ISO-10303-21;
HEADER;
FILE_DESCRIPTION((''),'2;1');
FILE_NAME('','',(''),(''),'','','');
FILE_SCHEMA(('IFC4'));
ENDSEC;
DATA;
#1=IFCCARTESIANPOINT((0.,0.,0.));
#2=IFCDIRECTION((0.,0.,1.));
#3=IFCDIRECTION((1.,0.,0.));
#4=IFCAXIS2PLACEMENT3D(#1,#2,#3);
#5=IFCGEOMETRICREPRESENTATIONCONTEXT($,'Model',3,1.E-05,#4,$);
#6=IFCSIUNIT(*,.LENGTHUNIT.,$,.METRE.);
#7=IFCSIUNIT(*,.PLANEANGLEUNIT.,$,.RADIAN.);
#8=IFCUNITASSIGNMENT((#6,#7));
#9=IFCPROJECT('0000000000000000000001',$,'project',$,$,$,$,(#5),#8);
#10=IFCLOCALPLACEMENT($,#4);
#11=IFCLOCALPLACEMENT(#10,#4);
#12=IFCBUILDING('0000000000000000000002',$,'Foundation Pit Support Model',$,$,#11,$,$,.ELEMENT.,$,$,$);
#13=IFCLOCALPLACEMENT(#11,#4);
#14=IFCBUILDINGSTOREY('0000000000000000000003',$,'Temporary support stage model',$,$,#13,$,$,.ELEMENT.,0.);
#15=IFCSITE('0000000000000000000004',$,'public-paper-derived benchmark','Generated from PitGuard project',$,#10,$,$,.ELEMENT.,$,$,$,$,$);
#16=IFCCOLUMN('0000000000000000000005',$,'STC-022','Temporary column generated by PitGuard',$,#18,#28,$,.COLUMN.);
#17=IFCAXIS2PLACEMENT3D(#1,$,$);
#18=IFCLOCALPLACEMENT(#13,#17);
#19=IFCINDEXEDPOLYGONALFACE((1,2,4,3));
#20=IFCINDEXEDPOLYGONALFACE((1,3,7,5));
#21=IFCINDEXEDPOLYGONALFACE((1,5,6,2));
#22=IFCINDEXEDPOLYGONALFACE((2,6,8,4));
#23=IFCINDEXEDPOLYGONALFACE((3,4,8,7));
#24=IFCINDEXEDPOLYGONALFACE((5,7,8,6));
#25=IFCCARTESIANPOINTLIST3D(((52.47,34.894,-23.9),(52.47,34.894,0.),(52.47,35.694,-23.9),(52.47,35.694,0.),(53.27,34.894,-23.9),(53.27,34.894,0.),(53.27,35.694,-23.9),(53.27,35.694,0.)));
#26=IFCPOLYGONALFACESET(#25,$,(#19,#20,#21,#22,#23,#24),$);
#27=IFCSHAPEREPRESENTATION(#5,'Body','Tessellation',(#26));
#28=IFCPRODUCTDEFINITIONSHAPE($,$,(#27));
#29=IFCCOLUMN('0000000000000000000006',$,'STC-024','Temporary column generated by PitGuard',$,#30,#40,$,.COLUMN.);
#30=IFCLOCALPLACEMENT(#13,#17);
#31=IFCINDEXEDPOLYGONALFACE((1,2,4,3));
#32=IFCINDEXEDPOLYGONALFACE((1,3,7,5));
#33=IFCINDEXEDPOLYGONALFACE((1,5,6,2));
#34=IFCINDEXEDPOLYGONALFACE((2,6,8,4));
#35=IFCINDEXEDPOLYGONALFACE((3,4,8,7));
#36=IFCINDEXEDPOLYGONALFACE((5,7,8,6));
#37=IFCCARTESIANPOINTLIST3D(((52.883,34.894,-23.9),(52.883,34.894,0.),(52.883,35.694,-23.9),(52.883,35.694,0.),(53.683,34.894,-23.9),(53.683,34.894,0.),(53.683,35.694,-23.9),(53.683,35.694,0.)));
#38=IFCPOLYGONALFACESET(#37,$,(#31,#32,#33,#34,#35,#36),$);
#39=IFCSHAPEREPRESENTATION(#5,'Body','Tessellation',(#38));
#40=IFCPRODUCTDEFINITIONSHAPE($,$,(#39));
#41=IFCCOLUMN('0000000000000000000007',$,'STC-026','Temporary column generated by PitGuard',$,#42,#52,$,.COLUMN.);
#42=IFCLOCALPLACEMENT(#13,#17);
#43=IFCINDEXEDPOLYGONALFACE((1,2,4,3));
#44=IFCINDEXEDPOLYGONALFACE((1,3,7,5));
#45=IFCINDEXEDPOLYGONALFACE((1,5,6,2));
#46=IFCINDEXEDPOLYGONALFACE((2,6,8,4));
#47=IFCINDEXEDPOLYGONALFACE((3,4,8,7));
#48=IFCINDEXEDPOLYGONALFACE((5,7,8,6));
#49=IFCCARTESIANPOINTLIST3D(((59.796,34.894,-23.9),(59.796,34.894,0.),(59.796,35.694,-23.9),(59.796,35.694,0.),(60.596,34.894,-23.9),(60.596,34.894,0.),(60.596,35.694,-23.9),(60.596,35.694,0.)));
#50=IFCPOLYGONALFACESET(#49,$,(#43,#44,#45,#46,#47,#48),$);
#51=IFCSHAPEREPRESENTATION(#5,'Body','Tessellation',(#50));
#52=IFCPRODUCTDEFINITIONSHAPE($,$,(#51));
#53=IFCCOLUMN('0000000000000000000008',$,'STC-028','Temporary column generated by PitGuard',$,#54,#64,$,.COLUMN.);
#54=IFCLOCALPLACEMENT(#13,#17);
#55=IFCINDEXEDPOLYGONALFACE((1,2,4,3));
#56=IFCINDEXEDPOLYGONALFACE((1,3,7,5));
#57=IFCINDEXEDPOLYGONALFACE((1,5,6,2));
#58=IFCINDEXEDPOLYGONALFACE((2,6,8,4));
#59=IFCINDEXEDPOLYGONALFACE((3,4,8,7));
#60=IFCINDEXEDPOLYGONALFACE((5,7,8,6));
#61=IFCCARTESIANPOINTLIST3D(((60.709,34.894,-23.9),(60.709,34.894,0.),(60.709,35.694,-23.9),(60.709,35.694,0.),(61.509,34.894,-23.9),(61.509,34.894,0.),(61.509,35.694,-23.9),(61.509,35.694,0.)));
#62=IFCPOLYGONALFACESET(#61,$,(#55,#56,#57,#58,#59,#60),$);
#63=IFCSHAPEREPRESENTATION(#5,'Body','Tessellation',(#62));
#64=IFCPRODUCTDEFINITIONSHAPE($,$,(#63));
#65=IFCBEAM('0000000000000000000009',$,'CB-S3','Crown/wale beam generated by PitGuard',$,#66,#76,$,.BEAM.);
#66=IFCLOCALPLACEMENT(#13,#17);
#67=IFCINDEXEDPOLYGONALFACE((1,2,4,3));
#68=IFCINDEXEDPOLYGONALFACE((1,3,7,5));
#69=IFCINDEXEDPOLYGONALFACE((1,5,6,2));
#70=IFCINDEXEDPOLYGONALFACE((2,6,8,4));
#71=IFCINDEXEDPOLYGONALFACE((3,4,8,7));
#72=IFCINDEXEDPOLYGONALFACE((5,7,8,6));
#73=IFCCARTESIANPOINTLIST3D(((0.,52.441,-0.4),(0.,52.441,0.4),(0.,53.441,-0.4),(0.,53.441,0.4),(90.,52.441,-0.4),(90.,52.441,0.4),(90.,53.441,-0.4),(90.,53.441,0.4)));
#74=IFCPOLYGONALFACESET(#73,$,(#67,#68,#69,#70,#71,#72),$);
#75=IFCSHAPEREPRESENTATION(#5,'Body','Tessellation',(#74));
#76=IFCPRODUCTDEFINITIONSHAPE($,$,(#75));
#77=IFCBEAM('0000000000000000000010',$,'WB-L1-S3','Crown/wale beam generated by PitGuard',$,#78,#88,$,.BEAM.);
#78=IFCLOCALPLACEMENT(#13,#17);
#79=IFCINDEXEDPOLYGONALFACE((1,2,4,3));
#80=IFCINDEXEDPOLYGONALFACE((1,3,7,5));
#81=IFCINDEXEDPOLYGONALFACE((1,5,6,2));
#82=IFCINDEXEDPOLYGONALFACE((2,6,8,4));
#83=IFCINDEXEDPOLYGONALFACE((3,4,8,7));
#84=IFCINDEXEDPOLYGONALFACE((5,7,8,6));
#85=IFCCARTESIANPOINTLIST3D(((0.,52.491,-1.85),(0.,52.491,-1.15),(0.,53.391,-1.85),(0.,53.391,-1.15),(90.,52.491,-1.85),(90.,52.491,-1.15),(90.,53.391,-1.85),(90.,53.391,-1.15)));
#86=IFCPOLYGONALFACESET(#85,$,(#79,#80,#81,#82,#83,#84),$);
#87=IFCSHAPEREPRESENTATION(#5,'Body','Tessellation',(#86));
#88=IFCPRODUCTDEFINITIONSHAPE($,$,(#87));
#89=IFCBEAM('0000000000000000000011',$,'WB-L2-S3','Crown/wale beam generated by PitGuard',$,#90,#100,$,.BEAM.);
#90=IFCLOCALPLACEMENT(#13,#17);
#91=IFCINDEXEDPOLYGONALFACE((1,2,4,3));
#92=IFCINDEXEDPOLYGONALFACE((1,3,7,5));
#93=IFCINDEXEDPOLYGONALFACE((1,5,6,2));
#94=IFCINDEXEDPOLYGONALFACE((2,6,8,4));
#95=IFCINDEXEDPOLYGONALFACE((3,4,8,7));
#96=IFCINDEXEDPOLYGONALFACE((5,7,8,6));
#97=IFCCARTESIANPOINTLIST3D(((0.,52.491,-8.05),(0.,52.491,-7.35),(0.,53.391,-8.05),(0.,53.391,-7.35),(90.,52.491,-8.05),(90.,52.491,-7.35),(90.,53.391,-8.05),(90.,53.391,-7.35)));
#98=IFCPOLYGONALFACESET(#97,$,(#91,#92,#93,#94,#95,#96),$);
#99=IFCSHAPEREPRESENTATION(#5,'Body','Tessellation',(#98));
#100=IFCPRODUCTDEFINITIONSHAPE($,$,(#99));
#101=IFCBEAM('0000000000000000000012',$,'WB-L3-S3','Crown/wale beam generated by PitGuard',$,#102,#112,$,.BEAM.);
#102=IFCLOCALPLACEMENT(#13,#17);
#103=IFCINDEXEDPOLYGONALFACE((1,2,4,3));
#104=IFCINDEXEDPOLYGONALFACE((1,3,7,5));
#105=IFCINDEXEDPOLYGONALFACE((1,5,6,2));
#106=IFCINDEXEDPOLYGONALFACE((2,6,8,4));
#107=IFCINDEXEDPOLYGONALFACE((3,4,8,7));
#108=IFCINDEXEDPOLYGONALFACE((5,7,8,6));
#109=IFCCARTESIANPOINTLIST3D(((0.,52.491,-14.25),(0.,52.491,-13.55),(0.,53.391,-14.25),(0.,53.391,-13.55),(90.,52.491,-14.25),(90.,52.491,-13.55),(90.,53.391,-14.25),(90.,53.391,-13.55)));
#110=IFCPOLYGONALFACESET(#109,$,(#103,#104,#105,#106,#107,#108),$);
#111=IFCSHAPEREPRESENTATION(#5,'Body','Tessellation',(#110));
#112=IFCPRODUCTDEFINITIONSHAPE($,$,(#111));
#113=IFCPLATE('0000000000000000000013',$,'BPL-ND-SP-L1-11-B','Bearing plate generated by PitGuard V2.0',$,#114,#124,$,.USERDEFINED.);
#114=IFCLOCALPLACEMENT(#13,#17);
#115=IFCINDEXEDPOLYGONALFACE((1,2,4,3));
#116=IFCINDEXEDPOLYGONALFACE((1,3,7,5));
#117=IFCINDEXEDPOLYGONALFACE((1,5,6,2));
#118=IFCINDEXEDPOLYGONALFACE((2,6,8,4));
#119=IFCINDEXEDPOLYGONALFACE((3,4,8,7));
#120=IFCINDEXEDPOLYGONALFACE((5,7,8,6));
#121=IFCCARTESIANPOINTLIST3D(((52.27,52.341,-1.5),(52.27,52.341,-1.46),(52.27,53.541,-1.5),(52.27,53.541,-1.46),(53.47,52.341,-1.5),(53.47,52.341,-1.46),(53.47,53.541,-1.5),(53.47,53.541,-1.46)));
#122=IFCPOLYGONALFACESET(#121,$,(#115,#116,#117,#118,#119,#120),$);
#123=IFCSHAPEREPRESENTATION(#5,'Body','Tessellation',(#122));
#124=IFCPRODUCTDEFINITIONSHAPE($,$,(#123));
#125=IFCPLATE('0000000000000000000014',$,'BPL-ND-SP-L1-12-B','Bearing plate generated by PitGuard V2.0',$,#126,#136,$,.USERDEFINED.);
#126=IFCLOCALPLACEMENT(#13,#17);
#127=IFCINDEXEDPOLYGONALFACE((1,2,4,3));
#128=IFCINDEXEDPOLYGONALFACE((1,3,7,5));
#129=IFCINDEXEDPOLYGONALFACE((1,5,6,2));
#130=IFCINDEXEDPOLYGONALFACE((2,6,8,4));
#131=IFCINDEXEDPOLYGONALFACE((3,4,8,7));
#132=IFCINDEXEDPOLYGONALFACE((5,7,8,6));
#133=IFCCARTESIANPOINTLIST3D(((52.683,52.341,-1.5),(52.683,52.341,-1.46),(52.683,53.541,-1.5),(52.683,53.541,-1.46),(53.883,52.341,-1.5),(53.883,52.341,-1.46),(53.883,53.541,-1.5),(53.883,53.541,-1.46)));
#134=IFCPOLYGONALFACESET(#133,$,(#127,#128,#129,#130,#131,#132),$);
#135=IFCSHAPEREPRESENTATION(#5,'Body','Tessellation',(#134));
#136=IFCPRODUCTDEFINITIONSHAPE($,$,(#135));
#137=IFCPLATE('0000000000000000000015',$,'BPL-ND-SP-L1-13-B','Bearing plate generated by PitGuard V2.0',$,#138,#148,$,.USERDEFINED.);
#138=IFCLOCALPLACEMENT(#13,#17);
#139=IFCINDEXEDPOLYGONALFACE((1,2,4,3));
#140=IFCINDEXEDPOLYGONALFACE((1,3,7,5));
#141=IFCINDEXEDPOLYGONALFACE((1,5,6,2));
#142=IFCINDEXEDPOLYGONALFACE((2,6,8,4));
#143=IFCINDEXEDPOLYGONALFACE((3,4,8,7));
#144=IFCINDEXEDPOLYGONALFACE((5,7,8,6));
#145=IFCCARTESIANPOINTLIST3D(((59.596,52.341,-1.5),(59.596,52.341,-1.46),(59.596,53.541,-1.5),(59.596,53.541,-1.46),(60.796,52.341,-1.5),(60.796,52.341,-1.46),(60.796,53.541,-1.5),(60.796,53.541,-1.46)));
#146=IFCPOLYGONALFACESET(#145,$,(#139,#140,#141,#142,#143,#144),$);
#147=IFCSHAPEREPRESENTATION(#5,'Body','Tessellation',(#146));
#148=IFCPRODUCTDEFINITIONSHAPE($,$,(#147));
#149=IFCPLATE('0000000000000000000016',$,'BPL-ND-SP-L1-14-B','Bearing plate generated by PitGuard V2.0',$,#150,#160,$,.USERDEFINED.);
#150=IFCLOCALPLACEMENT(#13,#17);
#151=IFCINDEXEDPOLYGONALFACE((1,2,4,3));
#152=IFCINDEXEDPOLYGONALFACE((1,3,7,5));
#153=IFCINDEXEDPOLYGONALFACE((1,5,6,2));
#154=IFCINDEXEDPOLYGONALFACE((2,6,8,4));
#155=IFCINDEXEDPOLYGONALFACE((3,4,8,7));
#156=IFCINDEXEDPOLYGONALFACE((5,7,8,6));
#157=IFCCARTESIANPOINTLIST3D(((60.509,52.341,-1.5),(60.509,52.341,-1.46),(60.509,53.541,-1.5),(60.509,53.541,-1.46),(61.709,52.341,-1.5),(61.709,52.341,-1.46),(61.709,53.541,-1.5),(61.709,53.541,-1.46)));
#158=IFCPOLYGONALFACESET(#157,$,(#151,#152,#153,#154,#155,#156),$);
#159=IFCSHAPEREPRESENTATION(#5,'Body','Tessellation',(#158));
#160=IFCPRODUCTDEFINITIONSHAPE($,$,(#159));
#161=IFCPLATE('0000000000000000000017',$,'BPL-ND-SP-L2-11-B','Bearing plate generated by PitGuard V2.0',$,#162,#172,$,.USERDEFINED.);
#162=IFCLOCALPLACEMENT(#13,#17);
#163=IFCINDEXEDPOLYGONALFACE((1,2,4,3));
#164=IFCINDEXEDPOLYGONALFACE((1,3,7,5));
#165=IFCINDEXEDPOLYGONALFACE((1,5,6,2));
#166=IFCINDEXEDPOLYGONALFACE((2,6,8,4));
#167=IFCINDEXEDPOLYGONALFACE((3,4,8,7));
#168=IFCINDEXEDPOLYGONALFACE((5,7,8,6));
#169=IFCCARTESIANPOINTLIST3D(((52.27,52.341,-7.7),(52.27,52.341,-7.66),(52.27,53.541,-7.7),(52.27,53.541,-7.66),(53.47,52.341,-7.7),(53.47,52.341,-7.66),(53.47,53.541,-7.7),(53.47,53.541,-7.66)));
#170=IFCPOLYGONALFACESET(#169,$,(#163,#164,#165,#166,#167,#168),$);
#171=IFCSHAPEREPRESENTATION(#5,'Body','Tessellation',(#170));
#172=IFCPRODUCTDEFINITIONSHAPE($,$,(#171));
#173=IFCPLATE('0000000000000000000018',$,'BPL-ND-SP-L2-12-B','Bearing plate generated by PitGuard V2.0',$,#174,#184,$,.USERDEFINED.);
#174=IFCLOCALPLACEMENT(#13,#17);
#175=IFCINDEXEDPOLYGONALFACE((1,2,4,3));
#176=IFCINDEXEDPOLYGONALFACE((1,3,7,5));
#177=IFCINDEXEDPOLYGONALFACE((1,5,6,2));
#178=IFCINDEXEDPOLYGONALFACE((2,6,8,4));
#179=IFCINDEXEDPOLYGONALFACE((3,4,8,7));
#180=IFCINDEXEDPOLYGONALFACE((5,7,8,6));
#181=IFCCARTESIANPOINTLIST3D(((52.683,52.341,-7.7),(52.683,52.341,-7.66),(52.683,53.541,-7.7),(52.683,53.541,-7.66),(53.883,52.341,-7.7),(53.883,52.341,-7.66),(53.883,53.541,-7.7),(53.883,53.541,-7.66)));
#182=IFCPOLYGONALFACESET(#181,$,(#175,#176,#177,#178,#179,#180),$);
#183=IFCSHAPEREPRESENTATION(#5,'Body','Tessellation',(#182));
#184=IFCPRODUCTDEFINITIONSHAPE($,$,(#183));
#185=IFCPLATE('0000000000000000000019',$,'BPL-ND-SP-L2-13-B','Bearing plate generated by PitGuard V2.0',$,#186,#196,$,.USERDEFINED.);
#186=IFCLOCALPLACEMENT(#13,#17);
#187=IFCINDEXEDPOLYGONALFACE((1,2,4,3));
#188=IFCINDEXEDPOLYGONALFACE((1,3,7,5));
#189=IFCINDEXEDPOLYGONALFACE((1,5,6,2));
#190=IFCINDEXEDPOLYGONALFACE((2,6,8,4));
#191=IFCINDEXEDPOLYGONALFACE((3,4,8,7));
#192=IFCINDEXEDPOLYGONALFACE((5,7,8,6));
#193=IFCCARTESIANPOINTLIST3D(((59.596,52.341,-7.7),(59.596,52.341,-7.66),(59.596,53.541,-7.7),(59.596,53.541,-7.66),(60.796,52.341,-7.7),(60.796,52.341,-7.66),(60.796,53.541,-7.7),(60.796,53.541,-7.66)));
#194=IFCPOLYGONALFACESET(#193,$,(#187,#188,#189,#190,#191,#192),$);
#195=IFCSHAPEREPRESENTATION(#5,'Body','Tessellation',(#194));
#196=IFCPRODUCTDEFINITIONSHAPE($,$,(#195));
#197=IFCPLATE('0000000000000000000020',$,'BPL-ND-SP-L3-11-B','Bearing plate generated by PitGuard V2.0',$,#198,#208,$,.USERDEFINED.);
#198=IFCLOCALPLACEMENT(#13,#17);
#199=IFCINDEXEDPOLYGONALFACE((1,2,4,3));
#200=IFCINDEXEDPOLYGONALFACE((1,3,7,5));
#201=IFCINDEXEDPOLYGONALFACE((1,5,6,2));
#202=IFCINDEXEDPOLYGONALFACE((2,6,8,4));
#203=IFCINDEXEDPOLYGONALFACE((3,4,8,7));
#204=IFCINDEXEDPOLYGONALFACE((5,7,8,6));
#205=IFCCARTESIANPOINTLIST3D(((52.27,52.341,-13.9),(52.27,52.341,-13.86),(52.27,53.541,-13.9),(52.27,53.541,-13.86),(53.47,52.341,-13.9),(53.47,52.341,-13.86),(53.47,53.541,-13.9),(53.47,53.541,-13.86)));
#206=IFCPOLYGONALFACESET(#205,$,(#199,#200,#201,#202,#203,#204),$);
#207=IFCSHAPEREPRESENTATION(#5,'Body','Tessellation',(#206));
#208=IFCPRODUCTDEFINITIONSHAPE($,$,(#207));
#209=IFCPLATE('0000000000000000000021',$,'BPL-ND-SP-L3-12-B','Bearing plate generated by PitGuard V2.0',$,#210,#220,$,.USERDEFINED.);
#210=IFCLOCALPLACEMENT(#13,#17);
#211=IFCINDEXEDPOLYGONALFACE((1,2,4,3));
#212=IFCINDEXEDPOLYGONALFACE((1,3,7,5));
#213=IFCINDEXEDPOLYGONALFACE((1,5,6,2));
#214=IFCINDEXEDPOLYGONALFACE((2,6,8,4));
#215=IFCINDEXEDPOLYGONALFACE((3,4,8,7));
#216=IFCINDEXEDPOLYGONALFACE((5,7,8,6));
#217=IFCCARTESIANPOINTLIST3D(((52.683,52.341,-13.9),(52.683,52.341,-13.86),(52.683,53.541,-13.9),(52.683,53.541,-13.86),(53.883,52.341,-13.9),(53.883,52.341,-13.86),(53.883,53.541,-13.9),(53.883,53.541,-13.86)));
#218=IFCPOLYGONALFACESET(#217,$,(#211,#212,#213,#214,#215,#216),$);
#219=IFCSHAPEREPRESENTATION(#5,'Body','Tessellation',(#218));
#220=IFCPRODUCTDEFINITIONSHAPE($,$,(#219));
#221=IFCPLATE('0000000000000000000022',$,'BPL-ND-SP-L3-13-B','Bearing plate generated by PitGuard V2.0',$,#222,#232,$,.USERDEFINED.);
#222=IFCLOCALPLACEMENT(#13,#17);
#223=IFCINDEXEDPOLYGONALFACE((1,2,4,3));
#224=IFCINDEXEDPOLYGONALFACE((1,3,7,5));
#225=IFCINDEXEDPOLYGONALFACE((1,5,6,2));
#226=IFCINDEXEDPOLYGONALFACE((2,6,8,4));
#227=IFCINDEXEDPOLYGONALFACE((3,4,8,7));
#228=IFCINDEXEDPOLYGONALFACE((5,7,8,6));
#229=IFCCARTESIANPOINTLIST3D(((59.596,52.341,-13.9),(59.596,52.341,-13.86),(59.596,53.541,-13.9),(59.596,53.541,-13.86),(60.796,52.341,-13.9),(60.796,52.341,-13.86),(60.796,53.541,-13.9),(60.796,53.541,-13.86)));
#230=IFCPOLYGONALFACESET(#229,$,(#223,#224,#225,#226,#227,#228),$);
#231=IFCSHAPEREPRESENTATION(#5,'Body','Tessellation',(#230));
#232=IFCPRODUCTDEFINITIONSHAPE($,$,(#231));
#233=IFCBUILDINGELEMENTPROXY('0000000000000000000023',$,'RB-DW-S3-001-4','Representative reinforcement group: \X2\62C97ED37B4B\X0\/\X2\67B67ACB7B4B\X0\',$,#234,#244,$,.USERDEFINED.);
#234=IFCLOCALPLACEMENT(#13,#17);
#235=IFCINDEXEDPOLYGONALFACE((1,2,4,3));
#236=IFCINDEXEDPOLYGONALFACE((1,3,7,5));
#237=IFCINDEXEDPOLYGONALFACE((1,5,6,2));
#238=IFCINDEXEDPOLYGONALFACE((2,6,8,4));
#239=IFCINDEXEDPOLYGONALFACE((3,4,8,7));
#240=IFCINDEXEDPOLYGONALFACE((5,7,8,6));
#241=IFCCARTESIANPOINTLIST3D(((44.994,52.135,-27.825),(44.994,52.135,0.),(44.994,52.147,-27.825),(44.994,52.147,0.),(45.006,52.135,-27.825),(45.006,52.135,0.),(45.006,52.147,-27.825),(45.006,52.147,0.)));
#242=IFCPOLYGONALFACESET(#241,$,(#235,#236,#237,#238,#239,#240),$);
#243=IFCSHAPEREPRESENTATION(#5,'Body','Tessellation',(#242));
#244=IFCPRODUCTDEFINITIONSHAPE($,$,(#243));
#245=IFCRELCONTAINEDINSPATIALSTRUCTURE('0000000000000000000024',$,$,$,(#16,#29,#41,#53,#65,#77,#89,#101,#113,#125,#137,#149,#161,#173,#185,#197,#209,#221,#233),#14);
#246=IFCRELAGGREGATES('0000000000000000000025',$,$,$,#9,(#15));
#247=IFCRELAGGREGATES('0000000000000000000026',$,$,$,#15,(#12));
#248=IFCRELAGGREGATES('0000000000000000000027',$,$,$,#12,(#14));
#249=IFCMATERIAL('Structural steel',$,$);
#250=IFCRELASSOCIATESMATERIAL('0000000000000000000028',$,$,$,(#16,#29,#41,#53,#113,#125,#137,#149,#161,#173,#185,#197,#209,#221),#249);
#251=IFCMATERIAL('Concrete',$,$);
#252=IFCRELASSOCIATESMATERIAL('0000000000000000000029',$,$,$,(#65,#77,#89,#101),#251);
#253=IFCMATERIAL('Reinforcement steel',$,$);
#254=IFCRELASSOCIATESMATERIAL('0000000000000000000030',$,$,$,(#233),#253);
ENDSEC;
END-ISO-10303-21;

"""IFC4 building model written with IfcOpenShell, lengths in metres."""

from ifc_helpers import new_model, si_unit, frame, origin_with_axes, origin_2d, place, context, project, spatial, rectangle, extrude, material, element, save


model = new_model("IFC4")

# Units and contexts
model_context = context("Model", 3, precision=1e-05, world=origin_with_axes())
ifc_project = project(units=[si_unit("LENGTHUNIT", "METRE"), si_unit("PLANEANGLEUNIT", "RADIAN")], contexts=[model_context])

# Site, building, storey
site_placement = place(None, origin_with_axes())
site = spatial("IfcSite", under=ifc_project, at=site_placement, Name="public-paper-derived benchmark", Description="Generated from PitGuard project", CompositionType="ELEMENT")
building_placement = place(site_placement, origin_with_axes())
building = spatial("IfcBuilding", under=site, at=building_placement, Name="Foundation Pit Support Model", CompositionType="ELEMENT")
storey_placement = place(building_placement, origin_with_axes())
storey = spatial("IfcBuildingStorey", under=building, at=storey_placement, Name="Temporary support stage model", CompositionType="ELEMENT", Elevation=0.0)

# Columns
ifc_material_1 = material(Name="Structural steel")
for number, where, z_axis, x_axis, name in (
    (1, (52.87, 35.294, -23.9), (0.0, 0.0, 1.0), (1.0, 0.0, 0.0), "STC-022"),
    (2, (53.283, 35.294, -23.9), (0.0, 0.0, 1.0), (1.0, 0.0, 0.0), "STC-024"),
    (3, (60.196, 35.294, -23.9), (0.0, 0.0, 1.0), (1.0, 0.0, 0.0), "STC-026"),
    (4, (61.109, 35.294, -23.9), (0.0, 0.0, 1.0), (1.0, 0.0, 0.0), "STC-028"),
):
    element("IfcColumn", number, at=place(storey_placement, frame(where, z_axis=z_axis, x_axis=x_axis)), inside=storey, material=ifc_material_1, Name=name, Description="Temporary column generated by PitGuard", PredefinedType="COLUMN", context=model_context, shape_type="SweptSolid", body=[
        extrude(rectangle(XDim=0.8, YDim=0.8, at=origin_2d()), origin_with_axes(), (0.0, 0.0, 1.0), 23.9),
    ])

# Beams
ifc_material_2 = material(Name="Concrete")
beam_placement = place(storey_placement, frame((45.0, 52.941, -0.4), z_axis=(0.0, 0.0, 1.0), x_axis=(-1.0, 0.0, 0.0)))
element("IfcBeam", 5, at=beam_placement, inside=storey, material=ifc_material_2, Name="CB-S3", Description="Crown/wale beam generated by PitGuard", PredefinedType="BEAM", context=model_context, shape_type="SweptSolid", body=[
    extrude(rectangle(XDim=90.0, YDim=1.0, at=origin_2d()), origin_with_axes(), (0.0, 0.0, 1.0), 0.8),
])
for number, where, z_axis, x_axis, name in (
    (6, (45.0, 52.941, -1.85), (0.0, 0.0, 1.0), (-1.0, 0.0, 0.0), "WB-L1-S3"),
    (7, (45.0, 52.941, -8.05), (0.0, 0.0, 1.0), (-1.0, 0.0, 0.0), "WB-L2-S3"),
    (8, (45.0, 52.941, -14.25), (0.0, 0.0, 1.0), (-1.0, 0.0, 0.0), "WB-L3-S3"),
):
    element("IfcBeam", number, at=place(storey_placement, frame(where, z_axis=z_axis, x_axis=x_axis)), inside=storey, material=ifc_material_2, Name=name, Description="Crown/wale beam generated by PitGuard", PredefinedType="BEAM", context=model_context, shape_type="SweptSolid", body=[
        extrude(rectangle(XDim=90.0, YDim=0.9, at=origin_2d()), origin_with_axes(), (0.0, 0.0, 1.0), 0.7),
    ])

# Plates
for number, where, z_axis, x_axis, name in (
    (9, (52.87, 52.941, -1.5), (0.0, 0.0, 1.0), (1.0, 0.0, 0.0), "BPL-ND-SP-L1-11-B"),
    (10, (53.283, 52.941, -1.5), (0.0, 0.0, 1.0), (1.0, 0.0, 0.0), "BPL-ND-SP-L1-12-B"),
    (11, (60.196, 52.941, -1.5), (0.0, 0.0, 1.0), (1.0, 0.0, 0.0), "BPL-ND-SP-L1-13-B"),
    (12, (61.109, 52.941, -1.5), (0.0, 0.0, 1.0), (1.0, 0.0, 0.0), "BPL-ND-SP-L1-14-B"),
    (13, (52.87, 52.941, -7.7), (0.0, 0.0, 1.0), (1.0, 0.0, 0.0), "BPL-ND-SP-L2-11-B"),
    (14, (53.283, 52.941, -7.7), (0.0, 0.0, 1.0), (1.0, 0.0, 0.0), "BPL-ND-SP-L2-12-B"),
    (15, (60.196, 52.941, -7.7), (0.0, 0.0, 1.0), (1.0, 0.0, 0.0), "BPL-ND-SP-L2-13-B"),
    (16, (52.87, 52.941, -13.9), (0.0, 0.0, 1.0), (1.0, 0.0, 0.0), "BPL-ND-SP-L3-11-B"),
    (17, (53.283, 52.941, -13.9), (0.0, 0.0, 1.0), (1.0, 0.0, 0.0), "BPL-ND-SP-L3-12-B"),
    (18, (60.196, 52.941, -13.9), (0.0, 0.0, 1.0), (1.0, 0.0, 0.0), "BPL-ND-SP-L3-13-B"),
):
    element("IfcPlate", number, at=place(storey_placement, frame(where, z_axis=z_axis, x_axis=x_axis)), inside=storey, material=ifc_material_1, Name=name, Description="Bearing plate generated by PitGuard V2.0", PredefinedType="USERDEFINED", context=model_context, shape_type="SweptSolid", body=[
        extrude(rectangle(XDim=1.2, YDim=1.2, at=origin_2d()), origin_with_axes(), (0.0, 0.0, 1.0), 0.04),
    ])

# Building element proxy
ifc_material_3 = material(Name="Reinforcement steel")
proxy_1_placement = place(storey_placement, frame((45.0, 52.141, -27.825), z_axis=(0.0, 0.0, 1.0), x_axis=(1.0, 0.0, 0.0)))
element("IfcBuildingElementProxy", 19, at=proxy_1_placement, inside=storey, material=ifc_material_3, Name="RB-DW-S3-001-4", Description="Representative reinforcement group: 拉结筋/架立筋", PredefinedType="USERDEFINED", context=model_context, shape_type="SweptSolid", body=[
    extrude(rectangle(XDim=0.012, YDim=0.012, at=origin_2d()), origin_with_axes(), (0.0, 0.0, 1.0), 27.825),
])

save(model, "model.ifc")
